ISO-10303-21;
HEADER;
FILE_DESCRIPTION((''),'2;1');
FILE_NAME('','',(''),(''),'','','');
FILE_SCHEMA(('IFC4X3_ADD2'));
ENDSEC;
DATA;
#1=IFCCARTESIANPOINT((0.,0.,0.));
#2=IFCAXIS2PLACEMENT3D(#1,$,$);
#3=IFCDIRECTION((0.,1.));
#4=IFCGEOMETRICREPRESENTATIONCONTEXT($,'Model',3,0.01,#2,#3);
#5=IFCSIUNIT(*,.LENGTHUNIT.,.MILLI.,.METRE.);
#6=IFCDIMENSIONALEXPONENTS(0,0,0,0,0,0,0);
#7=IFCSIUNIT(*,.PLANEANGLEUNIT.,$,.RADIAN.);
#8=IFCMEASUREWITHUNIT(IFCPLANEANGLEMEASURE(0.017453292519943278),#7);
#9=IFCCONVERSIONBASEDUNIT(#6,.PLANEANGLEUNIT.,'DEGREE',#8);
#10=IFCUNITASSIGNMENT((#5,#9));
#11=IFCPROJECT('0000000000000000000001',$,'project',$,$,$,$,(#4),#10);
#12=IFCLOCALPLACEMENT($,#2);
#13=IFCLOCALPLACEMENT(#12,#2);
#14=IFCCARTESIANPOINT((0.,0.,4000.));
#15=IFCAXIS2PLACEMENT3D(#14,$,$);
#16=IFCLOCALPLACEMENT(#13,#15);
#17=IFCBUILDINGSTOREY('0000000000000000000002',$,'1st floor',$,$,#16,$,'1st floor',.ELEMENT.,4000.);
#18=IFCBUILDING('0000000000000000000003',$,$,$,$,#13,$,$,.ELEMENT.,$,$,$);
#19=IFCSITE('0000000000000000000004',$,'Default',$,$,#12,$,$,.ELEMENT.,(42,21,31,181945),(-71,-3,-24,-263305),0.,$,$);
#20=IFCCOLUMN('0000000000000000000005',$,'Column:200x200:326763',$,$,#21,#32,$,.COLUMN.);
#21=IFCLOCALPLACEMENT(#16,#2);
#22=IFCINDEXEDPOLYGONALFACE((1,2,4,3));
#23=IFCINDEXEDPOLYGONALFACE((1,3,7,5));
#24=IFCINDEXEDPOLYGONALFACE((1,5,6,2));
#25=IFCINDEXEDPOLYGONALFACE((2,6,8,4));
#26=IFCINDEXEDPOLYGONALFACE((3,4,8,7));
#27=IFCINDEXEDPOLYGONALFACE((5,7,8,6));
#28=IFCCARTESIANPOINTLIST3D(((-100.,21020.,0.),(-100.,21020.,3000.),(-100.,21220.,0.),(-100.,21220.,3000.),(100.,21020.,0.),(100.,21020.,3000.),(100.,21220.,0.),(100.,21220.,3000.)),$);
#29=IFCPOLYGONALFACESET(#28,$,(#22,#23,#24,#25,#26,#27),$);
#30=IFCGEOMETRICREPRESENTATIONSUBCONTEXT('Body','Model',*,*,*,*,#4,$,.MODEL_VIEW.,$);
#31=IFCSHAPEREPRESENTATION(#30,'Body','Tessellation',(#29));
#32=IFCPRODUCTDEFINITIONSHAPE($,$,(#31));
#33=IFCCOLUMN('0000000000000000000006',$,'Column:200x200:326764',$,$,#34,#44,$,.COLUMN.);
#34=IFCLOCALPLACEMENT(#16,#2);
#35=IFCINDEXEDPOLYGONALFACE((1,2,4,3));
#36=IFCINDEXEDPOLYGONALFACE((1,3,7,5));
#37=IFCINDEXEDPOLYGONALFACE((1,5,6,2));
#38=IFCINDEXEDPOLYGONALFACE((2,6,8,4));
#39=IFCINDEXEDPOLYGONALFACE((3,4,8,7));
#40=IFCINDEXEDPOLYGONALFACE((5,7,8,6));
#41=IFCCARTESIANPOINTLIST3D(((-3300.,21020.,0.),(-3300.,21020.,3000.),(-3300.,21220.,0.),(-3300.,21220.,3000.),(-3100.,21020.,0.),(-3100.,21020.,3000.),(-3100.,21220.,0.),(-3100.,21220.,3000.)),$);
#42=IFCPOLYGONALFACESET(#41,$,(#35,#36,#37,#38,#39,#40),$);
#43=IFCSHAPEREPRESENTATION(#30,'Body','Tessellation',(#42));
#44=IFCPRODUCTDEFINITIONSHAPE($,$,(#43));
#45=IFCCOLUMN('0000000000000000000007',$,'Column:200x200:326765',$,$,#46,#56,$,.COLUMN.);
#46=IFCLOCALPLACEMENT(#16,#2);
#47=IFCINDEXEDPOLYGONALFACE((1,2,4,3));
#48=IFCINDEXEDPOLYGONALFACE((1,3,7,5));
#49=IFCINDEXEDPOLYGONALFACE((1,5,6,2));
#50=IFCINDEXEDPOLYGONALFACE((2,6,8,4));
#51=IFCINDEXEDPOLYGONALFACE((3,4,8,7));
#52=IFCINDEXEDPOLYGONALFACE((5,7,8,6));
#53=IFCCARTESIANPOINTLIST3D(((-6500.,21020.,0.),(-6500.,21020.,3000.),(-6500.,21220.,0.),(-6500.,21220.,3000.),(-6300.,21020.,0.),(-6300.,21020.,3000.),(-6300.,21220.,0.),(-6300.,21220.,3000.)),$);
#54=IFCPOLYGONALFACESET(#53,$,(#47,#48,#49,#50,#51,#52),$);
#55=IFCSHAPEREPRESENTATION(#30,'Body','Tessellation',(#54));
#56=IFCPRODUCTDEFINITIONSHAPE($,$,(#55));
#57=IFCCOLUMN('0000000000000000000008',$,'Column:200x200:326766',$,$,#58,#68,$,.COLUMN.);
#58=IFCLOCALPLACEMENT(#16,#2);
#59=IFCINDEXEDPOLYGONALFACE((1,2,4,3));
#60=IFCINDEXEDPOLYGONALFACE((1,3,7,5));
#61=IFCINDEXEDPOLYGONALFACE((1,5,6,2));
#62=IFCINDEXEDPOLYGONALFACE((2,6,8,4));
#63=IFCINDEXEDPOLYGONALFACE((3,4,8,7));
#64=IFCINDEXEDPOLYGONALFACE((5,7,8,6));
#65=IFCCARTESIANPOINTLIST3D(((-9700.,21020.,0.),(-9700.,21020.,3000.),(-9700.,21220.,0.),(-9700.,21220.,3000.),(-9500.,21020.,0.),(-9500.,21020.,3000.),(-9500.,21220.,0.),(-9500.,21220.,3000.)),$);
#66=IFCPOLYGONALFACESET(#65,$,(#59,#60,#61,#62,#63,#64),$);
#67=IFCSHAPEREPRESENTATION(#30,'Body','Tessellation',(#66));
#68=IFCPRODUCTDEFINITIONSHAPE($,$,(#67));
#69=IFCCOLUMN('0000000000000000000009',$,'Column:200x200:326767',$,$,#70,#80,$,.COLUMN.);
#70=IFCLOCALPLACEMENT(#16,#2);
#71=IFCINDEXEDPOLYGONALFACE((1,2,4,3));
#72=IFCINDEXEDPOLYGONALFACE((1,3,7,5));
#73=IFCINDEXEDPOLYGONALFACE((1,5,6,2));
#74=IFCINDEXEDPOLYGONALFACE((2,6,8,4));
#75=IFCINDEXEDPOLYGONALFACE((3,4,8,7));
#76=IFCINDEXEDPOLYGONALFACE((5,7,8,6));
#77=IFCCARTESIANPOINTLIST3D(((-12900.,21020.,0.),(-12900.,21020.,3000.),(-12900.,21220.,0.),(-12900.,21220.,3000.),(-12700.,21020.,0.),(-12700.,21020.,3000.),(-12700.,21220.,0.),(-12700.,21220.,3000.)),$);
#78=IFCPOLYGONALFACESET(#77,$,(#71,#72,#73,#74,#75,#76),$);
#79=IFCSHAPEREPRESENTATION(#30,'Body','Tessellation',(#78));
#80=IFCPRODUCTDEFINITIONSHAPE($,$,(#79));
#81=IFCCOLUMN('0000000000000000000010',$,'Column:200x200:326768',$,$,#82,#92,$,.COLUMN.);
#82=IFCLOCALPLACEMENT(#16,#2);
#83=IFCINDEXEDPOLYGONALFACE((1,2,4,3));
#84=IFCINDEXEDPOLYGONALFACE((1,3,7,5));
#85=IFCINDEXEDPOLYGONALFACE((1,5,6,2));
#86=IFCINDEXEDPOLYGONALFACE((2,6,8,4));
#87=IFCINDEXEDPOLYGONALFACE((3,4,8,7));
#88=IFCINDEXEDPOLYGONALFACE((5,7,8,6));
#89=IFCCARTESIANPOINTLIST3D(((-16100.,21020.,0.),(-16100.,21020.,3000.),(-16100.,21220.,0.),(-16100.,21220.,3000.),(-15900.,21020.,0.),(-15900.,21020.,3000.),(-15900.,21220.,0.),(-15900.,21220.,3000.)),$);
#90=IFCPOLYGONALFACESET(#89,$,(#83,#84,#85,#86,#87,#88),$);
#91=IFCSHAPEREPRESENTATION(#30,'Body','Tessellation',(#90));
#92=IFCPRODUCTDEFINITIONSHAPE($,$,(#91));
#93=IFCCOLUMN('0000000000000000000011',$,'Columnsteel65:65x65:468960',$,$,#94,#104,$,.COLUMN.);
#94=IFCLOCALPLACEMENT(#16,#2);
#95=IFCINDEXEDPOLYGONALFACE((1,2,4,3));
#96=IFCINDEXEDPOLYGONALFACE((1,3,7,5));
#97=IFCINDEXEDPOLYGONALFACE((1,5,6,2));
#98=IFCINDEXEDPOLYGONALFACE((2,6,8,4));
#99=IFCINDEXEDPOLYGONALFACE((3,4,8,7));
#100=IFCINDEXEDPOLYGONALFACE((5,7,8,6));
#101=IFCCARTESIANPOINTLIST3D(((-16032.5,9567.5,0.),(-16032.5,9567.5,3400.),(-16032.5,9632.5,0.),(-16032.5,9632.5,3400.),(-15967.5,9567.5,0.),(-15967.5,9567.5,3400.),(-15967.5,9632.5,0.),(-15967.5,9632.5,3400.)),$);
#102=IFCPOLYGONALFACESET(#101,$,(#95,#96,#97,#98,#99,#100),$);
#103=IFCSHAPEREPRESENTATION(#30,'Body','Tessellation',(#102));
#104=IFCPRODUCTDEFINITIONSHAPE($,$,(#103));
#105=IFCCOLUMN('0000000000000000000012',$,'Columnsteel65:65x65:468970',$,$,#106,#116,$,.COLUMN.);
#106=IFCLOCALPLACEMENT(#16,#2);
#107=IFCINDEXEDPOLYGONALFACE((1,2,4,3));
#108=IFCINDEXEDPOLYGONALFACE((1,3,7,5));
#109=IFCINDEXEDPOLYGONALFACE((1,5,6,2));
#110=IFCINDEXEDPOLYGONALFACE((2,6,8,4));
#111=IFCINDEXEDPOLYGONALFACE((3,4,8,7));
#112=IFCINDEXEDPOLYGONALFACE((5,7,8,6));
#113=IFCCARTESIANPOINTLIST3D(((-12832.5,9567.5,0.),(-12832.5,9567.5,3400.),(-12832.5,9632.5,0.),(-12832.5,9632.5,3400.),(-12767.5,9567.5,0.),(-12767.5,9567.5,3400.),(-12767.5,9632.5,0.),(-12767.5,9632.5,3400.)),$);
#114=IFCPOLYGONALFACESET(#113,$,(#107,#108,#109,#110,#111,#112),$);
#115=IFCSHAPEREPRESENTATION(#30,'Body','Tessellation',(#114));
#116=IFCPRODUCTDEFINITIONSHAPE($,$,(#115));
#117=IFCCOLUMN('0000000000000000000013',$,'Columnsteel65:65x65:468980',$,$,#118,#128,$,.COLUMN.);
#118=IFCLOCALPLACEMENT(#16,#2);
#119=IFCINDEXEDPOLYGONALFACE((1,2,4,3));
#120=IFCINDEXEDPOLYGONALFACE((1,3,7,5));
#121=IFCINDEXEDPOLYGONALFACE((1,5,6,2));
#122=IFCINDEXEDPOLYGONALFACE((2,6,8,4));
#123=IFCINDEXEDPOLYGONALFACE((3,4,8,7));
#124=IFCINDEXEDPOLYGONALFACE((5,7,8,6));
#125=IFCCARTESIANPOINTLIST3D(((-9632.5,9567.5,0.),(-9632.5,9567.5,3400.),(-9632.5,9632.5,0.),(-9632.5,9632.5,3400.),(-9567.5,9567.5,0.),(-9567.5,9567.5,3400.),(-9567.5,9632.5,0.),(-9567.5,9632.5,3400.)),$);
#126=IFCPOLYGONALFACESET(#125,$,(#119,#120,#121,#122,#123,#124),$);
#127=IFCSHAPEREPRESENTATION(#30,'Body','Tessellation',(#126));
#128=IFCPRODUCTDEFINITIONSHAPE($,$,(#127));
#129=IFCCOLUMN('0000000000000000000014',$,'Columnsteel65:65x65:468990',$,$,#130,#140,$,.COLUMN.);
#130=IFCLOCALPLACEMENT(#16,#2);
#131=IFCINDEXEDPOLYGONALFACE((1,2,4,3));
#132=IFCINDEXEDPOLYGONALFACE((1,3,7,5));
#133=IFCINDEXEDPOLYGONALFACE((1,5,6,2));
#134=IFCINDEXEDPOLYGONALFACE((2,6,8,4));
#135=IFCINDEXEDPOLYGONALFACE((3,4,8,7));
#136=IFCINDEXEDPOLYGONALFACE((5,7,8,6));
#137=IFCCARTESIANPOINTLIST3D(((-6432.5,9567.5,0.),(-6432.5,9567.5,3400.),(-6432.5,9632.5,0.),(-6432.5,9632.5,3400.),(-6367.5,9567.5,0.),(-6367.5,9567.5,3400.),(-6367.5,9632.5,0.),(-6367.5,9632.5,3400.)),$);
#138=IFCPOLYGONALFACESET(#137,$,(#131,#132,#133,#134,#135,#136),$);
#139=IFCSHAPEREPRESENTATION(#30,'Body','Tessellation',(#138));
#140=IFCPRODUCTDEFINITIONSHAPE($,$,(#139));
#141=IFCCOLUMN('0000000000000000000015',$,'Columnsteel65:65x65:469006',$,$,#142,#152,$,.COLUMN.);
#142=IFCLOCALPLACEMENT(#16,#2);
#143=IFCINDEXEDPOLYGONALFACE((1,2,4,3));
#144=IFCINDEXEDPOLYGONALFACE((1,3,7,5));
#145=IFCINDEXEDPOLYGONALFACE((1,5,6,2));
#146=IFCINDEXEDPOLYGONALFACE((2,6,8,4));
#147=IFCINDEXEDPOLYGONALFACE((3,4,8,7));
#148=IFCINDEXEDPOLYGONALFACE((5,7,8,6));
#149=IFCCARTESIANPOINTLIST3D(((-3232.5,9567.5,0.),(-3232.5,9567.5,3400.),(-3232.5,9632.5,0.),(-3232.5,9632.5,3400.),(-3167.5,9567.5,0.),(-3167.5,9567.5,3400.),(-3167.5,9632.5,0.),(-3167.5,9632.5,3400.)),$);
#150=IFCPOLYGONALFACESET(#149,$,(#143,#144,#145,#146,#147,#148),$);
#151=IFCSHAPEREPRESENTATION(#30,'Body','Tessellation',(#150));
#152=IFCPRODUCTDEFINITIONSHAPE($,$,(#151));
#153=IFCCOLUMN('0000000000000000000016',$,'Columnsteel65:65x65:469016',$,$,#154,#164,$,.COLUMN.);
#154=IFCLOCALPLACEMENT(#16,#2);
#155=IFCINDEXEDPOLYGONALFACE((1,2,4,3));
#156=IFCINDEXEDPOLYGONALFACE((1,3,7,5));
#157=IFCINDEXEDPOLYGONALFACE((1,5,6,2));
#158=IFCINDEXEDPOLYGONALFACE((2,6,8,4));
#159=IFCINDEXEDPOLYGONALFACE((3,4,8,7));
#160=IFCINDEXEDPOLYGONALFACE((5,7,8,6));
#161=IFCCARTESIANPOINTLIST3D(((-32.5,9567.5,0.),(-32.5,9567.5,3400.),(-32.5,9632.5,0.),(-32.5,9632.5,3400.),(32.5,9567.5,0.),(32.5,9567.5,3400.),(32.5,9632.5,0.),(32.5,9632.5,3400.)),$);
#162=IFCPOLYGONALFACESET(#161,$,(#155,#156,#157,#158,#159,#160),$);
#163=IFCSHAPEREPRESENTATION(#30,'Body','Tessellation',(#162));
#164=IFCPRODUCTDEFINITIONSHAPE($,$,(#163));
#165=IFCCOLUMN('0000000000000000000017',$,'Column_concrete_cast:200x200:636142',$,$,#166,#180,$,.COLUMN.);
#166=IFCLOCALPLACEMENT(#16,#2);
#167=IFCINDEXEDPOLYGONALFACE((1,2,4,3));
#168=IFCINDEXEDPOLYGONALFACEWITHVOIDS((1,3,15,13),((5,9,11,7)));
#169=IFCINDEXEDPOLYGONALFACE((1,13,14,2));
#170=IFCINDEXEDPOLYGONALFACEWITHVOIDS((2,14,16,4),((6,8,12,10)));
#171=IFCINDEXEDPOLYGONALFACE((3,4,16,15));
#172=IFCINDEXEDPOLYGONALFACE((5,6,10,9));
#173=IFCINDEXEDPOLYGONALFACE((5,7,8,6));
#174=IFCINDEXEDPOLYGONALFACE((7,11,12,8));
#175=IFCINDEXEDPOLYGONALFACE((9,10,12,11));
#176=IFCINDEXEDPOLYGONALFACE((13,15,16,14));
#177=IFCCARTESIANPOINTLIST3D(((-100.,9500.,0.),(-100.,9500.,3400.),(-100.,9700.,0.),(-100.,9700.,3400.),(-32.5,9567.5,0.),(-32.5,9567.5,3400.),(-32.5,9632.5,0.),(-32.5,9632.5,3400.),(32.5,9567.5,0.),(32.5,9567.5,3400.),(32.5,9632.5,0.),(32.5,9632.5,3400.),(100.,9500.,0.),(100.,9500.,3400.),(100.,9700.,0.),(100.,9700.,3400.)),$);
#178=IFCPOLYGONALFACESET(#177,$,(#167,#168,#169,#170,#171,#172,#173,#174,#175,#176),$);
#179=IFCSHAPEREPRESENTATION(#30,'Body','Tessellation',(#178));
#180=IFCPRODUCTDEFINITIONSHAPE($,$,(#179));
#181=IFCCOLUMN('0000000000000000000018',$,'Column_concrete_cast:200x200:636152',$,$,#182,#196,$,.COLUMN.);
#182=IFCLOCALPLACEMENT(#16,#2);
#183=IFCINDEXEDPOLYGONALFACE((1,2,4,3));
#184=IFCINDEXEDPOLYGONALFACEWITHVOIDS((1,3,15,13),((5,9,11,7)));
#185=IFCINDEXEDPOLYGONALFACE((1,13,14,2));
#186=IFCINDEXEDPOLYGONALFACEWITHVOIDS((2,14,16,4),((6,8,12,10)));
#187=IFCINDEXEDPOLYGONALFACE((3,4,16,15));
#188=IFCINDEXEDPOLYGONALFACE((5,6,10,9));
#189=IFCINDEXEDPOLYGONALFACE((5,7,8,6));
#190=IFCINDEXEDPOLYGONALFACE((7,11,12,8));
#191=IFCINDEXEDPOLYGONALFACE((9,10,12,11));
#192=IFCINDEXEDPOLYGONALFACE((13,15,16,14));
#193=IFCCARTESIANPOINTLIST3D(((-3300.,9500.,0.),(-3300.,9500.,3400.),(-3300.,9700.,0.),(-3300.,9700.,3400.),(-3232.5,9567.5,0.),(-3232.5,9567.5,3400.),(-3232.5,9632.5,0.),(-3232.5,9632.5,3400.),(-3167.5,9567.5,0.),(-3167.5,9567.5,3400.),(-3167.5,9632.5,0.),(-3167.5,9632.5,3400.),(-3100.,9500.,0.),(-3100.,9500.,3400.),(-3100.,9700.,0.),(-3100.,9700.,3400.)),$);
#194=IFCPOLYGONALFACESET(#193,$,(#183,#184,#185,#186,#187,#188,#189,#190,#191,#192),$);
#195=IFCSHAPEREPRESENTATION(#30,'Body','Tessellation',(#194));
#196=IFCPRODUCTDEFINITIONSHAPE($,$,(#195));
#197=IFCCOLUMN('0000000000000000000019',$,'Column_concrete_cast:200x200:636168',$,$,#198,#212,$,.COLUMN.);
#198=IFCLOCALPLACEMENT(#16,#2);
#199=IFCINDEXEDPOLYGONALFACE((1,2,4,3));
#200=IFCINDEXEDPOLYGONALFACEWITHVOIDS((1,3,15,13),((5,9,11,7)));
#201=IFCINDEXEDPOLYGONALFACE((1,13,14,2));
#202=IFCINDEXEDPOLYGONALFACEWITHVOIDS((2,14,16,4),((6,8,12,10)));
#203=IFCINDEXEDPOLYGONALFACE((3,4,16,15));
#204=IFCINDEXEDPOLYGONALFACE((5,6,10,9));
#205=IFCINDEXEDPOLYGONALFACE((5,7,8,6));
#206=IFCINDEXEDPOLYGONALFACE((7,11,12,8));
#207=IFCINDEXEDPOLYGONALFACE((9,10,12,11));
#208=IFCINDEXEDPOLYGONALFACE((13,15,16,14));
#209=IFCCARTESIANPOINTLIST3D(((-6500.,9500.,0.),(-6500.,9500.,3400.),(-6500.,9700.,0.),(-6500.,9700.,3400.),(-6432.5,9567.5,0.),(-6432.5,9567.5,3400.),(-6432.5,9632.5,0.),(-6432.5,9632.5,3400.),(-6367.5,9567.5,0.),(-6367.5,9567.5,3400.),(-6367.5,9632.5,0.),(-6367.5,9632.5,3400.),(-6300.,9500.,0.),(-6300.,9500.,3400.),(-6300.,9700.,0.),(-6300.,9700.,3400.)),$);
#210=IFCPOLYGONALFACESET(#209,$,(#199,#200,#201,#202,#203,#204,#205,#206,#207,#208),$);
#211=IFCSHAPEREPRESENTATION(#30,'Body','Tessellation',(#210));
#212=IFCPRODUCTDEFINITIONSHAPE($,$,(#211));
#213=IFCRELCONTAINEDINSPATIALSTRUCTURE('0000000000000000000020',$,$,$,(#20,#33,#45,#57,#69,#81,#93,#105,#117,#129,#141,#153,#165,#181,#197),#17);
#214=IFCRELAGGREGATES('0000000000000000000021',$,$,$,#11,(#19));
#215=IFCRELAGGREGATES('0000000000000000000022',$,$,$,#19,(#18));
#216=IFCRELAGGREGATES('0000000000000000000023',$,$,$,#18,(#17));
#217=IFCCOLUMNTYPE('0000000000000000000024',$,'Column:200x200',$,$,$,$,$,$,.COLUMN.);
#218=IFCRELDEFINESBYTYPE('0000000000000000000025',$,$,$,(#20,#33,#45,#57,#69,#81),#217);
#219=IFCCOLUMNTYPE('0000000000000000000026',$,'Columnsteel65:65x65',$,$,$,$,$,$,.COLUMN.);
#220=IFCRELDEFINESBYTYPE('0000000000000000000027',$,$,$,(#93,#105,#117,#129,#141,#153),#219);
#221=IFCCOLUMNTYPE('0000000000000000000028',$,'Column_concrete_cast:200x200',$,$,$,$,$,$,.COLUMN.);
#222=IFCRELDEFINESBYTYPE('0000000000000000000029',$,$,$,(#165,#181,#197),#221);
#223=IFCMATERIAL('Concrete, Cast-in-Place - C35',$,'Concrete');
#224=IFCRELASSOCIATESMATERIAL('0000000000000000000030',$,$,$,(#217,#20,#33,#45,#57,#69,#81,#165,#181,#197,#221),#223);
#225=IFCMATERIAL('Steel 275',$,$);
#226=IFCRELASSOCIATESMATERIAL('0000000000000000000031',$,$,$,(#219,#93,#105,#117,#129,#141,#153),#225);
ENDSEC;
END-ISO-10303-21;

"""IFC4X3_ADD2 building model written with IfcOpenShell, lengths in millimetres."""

from ifc_helpers import new_model, entity, si_unit, converted_unit, direction, frame, frame_2d, origin, place, context, subcontext, project, spatial, polyline, rectangle, outline, extrude, source, transform, mapped, material, material_profile, profile_set, profile_usage, type_object, type_shapes, element, save


model = new_model("IFC4X3_ADD2")

# Units and contexts
model_context = context("Model", 3, precision=0.01, world=origin(), true_north=direction((0.0, 1.0)))
body_context = subcontext(model_context, "Body", "Model", "MODEL_VIEW")
ifc_project = project(units=[si_unit("LENGTHUNIT", "METRE", prefix="MILLI"), converted_unit("PLANEANGLEUNIT", "DEGREE", entity("IfcPlaneAngleMeasure", 0.017453292519943278), si_unit("PLANEANGLEUNIT", "RADIAN"), dimensions=[0, 0, 0, 0, 0, 0, 0])], contexts=[model_context])

# Site, building, storey
site_placement = place(None, origin())
site = spatial("IfcSite", under=ifc_project, at=site_placement, Name="Default", CompositionType="ELEMENT", RefLatitude=(42, 21, 31, 181945), RefLongitude=(-71, -3, -24, -263305), RefElevation=0.0)
building_placement = place(site_placement, origin())
building = spatial("IfcBuilding", under=site, at=building_placement, CompositionType="ELEMENT")
storey_placement = place(building_placement, frame((0.0, 0.0, 4000.0)))
storey = spatial("IfcBuildingStorey", under=building, at=storey_placement, Name="1st floor", LongName="1st floor", CompositionType="ELEMENT", Elevation=4000.0)

# Columns
ifc_material_1 = material(Name="Concrete, Cast-in-Place - C35", Category="Concrete")
ifc_material_profile_1 = material_profile(ifc_material_1, rectangle(XDim=200.0, YDim=200.0, at=frame_2d((0.0, 0.0), x_axis=(1.0, 0.0))), Name="200x200")
ifc_profile_set_1 = profile_set([ifc_material_profile_1], Name="200x200")
ifc_profile_usage_1 = profile_usage(ifc_profile_set_1)
column_type_1 = type_object("IfcColumnType", Name="Column:200x200", PredefinedType="COLUMN", material=ifc_profile_set_1)
shared_shape_1 = source(origin(), body_context, "Body", "SweptSolid", [
    extrude(rectangle(XDim=200.0, YDim=200.0, at=frame_2d((0.0, 0.0), x_axis=(1.0, 0.0))), frame((0.0, 0.0, 4000.0), z_axis=(0.0, 0.0, 1.0), x_axis=(-1.0, 0.0, 0.0)), (0.0, 0.0, 1.0), 3000.0),
])
type_shapes(column_type_1, [shared_shape_1])
for number, where, name in (
    (1, (0.0, 21120.0, -4000.0), "Column:200x200:326763"),
    (2, (-3200.0, 21120.0, -4000.0), "Column:200x200:326764"),
    (3, (-6400.0, 21120.0, -4000.0), "Column:200x200:326765"),
    (4, (-9600.0, 21120.0, -4000.0), "Column:200x200:326766"),
    (5, (-12800.0, 21120.0, -4000.0), "Column:200x200:326767"),
    (6, (-16000.0, 21120.0, -4000.0), "Column:200x200:326768"),
):
    element("IfcColumn", number, at=place(storey_placement, frame(where)), inside=storey, type_object=column_type_1, material=ifc_profile_usage_1, Name=name, PredefinedType="COLUMN", context=body_context, shape_type="MappedRepresentation", body=[
        mapped(shared_shape_1, transform((0.0, 0.0, 0.0), scale=1.0)),
    ])
ifc_material_2 = material(Name="Steel 275")
ifc_material_profile_2 = material_profile(ifc_material_2, rectangle(XDim=65.0, YDim=65.0, at=frame_2d((0.0, 0.0), x_axis=(1.0, 0.0))), Name="65x65")
ifc_profile_set_2 = profile_set([ifc_material_profile_2], Name="65x65")
ifc_profile_usage_2 = profile_usage(ifc_profile_set_2)
column_type_2 = type_object("IfcColumnType", Name="Columnsteel65:65x65", PredefinedType="COLUMN", material=ifc_profile_set_2)
shared_shape_2 = source(origin(), body_context, "Body", "SweptSolid", [
    extrude(rectangle(XDim=65.0, YDim=65.0, at=frame_2d((0.0, 0.0), x_axis=(1.0, 0.0))), frame((0.0, 0.0, 4000.0), z_axis=(0.0, 0.0, 1.0), x_axis=(-1.0, 0.0, 0.0)), (0.0, 0.0, 1.0), 3400.0),
])
type_shapes(column_type_2, [shared_shape_2])
for number, where, name in (
    (7, (-16000.0, 9600.0, -4000.0), "Columnsteel65:65x65:468960"),
    (8, (-12800.0, 9600.0, -4000.0), "Columnsteel65:65x65:468970"),
    (9, (-9600.0, 9600.0, -4000.0), "Columnsteel65:65x65:468980"),
    (10, (-6400.0, 9600.0, -4000.0), "Columnsteel65:65x65:468990"),
    (11, (-3200.0, 9600.0, -4000.0), "Columnsteel65:65x65:469006"),
    (12, (0.0, 9600.0, -4000.0), "Columnsteel65:65x65:469016"),
):
    element("IfcColumn", number, at=place(storey_placement, frame(where)), inside=storey, type_object=column_type_2, material=ifc_profile_usage_2, Name=name, PredefinedType="COLUMN", context=body_context, shape_type="MappedRepresentation", body=[
        mapped(shared_shape_2, transform((0.0, 0.0, 0.0), scale=1.0)),
    ])
ifc_material_profile_3 = material_profile(ifc_material_1, outline(polyline([(-100.0, -100.0), (100.0, -100.0), (100.0, 100.0), (-100.0, 100.0), (-100.0, -100.0)]), holes=[polyline([(-32.5, 32.5), (32.5, 32.5), (32.5, -32.5), (-32.5, -32.5), (-32.5, 32.5)])]), Name="200x200")
ifc_profile_set_3 = profile_set([ifc_material_profile_3], Name="200x200")
column_type_3 = type_object("IfcColumnType", Name="Column_concrete_cast:200x200", PredefinedType="COLUMN", material=ifc_profile_set_3)
shared_shape_3 = source(origin(), body_context, "Body", "SweptSolid", [
    extrude(outline(polyline([(-100.0, -100.0), (100.0, -100.0), (100.0, 100.0), (-100.0, 100.0), (-100.0, -100.0)]), holes=[polyline([(-32.5, 32.5), (32.5, 32.5), (32.5, -32.5), (-32.5, -32.5), (-32.5, 32.5)])]), frame((0.0, 0.0, 4000.0), z_axis=(0.0, 0.0, 1.0), x_axis=(-1.0, 0.0, 0.0)), (0.0, 0.0, 1.0), 3400.0),
])
type_shapes(column_type_3, [shared_shape_3])
for number, where, name in (
    (13, (0.0, 9600.0, -4000.0), "Column_concrete_cast:200x200:636142"),
    (14, (-3200.0, 9600.0, -4000.0), "Column_concrete_cast:200x200:636152"),
    (15, (-6400.0, 9600.0, -4000.0), "Column_concrete_cast:200x200:636168"),
):
    element("IfcColumn", number, at=place(storey_placement, frame(where)), inside=storey, type_object=column_type_3, material=ifc_profile_usage_1, Name=name, PredefinedType="COLUMN", context=body_context, shape_type="MappedRepresentation", body=[
        mapped(shared_shape_3, transform((0.0, 0.0, 0.0), scale=1.0)),
    ])

save(model, "model.ifc")
